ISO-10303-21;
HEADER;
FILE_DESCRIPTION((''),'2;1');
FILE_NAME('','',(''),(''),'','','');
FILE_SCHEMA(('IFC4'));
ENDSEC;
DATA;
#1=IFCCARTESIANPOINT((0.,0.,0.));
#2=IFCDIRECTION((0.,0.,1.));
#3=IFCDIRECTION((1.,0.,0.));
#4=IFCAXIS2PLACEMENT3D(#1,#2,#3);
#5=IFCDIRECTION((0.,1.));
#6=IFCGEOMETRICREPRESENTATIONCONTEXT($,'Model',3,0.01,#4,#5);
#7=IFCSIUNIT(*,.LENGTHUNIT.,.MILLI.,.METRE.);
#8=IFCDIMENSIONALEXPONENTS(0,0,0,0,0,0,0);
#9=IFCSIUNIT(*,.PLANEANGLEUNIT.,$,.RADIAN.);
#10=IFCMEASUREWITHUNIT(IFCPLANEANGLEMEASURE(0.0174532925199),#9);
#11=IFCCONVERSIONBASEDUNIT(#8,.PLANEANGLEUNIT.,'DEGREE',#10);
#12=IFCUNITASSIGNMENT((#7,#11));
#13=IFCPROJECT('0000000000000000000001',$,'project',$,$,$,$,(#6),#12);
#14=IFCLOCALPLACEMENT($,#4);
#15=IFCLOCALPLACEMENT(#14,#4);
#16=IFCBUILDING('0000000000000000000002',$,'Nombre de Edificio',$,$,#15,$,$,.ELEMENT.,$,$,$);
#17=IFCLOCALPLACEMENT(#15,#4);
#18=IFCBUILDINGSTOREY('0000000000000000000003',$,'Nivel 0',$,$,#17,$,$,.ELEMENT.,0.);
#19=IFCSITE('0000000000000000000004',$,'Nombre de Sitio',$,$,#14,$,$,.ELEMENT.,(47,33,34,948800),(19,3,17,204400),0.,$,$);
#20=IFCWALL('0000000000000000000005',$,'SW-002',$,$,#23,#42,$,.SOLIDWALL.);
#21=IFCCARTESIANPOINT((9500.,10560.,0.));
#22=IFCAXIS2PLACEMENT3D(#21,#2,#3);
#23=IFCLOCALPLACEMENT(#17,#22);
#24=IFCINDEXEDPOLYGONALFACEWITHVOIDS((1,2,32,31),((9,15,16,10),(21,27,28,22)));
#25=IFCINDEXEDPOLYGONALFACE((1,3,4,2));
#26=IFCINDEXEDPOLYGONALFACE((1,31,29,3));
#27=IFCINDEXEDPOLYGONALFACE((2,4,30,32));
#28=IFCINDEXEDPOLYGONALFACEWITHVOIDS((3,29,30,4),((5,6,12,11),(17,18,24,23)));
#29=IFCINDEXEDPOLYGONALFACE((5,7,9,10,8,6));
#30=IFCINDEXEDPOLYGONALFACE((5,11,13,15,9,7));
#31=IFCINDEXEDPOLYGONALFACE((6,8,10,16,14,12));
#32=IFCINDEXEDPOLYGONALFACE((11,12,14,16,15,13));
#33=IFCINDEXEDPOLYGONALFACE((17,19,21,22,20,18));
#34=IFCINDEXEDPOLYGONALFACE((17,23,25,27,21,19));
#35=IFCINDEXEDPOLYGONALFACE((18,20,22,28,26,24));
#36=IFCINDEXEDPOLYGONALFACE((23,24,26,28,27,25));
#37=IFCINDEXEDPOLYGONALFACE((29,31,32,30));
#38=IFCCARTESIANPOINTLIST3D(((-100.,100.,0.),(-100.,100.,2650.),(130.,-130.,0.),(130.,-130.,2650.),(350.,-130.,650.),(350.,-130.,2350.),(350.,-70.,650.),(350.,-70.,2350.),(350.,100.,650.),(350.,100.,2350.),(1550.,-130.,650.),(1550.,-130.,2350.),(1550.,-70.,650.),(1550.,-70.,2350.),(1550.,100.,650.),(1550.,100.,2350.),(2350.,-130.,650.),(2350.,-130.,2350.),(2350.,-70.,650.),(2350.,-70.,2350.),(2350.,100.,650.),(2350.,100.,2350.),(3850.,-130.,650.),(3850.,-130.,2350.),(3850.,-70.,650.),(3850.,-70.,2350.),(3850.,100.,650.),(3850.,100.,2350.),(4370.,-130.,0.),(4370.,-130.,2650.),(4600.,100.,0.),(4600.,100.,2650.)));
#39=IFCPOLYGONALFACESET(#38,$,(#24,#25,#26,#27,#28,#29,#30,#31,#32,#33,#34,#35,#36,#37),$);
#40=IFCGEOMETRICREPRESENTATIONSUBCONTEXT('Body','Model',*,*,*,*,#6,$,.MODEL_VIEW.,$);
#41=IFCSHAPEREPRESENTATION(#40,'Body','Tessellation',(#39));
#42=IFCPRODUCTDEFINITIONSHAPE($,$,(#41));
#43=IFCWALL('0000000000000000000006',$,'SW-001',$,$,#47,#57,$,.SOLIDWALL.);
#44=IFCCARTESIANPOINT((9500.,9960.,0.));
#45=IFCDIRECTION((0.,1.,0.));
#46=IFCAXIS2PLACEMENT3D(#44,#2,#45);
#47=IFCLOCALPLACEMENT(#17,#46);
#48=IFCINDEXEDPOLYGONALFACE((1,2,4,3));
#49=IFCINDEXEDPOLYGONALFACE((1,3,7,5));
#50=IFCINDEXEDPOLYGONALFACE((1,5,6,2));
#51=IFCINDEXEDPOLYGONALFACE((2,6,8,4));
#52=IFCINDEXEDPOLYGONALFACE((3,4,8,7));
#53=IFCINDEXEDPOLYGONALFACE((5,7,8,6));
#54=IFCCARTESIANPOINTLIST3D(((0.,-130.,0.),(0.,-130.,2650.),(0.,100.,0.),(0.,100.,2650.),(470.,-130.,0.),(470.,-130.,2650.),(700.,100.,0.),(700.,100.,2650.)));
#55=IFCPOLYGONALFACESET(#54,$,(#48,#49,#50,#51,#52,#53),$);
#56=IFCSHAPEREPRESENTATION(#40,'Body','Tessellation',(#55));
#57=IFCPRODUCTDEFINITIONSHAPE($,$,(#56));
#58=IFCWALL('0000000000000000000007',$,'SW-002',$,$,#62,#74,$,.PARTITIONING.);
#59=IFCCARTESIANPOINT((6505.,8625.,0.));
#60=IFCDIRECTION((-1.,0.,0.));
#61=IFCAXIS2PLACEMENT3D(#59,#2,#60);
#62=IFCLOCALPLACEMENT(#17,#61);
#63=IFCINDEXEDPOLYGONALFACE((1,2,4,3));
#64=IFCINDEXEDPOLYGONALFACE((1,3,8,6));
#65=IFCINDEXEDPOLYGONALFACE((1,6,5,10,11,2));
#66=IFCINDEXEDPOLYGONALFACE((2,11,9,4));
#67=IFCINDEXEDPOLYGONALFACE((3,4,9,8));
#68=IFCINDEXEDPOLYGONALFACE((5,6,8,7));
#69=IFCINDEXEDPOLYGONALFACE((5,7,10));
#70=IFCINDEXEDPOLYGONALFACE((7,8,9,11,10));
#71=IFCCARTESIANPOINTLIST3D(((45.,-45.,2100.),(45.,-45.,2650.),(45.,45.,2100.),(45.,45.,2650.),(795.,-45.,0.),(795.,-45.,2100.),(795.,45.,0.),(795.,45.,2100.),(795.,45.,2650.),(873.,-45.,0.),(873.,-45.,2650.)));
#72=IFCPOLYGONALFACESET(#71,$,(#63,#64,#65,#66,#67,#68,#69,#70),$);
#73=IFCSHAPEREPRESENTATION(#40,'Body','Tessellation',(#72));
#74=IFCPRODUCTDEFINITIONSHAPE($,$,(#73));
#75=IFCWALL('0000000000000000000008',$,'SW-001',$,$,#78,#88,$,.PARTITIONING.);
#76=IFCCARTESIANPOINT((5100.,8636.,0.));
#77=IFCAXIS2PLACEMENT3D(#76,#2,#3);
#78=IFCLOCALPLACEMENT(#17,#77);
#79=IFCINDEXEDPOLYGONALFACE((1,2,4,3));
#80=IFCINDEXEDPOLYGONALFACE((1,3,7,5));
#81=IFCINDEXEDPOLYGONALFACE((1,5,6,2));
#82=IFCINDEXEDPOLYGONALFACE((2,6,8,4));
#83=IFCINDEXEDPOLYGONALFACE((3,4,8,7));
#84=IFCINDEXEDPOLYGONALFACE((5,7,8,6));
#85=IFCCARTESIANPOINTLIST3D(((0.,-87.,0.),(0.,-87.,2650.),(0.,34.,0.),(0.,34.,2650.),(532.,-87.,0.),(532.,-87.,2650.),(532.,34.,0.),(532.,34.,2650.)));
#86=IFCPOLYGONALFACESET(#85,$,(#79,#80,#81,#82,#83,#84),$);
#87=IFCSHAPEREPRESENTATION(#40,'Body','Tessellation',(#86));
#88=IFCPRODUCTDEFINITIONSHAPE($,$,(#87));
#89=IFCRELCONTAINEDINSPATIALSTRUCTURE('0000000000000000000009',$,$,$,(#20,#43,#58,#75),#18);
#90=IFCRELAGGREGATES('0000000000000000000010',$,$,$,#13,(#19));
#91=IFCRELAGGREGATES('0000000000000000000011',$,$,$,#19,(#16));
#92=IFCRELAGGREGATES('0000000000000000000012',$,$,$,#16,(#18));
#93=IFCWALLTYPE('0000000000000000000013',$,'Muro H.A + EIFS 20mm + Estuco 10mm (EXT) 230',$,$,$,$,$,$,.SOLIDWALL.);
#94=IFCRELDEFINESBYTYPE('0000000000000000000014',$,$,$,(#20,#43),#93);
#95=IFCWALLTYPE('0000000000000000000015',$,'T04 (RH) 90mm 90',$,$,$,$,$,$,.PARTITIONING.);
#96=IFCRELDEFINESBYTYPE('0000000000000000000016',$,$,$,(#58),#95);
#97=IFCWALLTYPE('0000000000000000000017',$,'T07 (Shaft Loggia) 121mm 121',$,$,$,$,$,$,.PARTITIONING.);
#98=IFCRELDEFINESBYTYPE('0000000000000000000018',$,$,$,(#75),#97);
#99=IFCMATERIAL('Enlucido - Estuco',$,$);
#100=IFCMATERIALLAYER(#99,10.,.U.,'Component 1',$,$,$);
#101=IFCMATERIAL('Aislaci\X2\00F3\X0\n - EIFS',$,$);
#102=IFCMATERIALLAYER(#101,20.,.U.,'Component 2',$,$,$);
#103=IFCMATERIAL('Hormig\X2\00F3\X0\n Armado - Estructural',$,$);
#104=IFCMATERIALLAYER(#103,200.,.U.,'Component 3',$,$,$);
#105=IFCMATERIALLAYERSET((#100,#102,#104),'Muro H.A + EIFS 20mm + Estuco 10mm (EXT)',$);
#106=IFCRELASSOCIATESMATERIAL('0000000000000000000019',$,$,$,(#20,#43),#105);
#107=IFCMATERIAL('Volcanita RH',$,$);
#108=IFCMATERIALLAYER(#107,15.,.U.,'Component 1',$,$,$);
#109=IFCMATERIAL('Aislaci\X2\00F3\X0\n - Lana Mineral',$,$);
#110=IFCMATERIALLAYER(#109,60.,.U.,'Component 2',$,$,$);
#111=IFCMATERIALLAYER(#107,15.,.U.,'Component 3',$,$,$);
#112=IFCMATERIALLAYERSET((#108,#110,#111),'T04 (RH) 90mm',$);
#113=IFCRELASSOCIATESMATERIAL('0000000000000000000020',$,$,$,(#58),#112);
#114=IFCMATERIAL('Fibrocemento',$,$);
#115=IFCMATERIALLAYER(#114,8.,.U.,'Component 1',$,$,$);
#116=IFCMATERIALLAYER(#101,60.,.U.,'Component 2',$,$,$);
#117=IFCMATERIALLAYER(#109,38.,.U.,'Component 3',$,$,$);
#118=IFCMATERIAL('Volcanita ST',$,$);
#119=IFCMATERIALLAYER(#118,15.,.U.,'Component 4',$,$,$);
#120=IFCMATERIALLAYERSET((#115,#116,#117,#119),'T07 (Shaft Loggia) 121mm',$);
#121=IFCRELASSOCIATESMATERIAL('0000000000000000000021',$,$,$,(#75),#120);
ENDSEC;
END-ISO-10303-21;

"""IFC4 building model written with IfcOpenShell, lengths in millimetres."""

from ifc_helpers import new_model, entity, si_unit, converted_unit, direction, frame, origin_with_axes, origin_2d_with_axis, place, context, subcontext, project, spatial, line, indexed_curve, rectangle, outline, extrude, material, layer, layer_set, layer_usage, type_object, element, save


model = new_model("IFC4")

# Units and contexts
model_context = context("Model", 3, precision=0.01, world=origin_with_axes(), true_north=direction((0.0, 1.0)))
body_context = subcontext(model_context, "Body", "Model", "MODEL_VIEW")
ifc_project = project(units=[si_unit("LENGTHUNIT", "METRE", prefix="MILLI"), converted_unit("PLANEANGLEUNIT", "DEGREE", entity("IfcPlaneAngleMeasure", 0.0174532925199), si_unit("PLANEANGLEUNIT", "RADIAN"), dimensions=[0, 0, 0, 0, 0, 0, 0])], contexts=[model_context])

# Site, building, storey
site_placement = place(None, origin_with_axes())
site = spatial("IfcSite", under=ifc_project, at=site_placement, Name="Nombre de Sitio", CompositionType="ELEMENT", RefLatitude=(47, 33, 34, 948800), RefLongitude=(19, 3, 17, 204400), RefElevation=0.0)
building_placement = place(site_placement, origin_with_axes())
building = spatial("IfcBuilding", under=site, at=building_placement, Name="Nombre de Edificio", CompositionType="ELEMENT")
storey_placement = place(building_placement, origin_with_axes())
storey = spatial("IfcBuildingStorey", under=building, at=storey_placement, Name="Nivel 0", CompositionType="ELEMENT", Elevation=0.0)

# Wall, openings
ifc_material_1 = material(Name="Enlucido - Estuco")
ifc_layer_1 = layer(ifc_material_1, 10.0, ventilated="UNKNOWN", Name="Component 1")
ifc_material_2 = material(Name="Aislación - EIFS")
ifc_layer_2 = layer(ifc_material_2, 20.0, ventilated="UNKNOWN", Name="Component 2")
ifc_material_3 = material(Name="Hormigón Armado - Estructural")
ifc_layer_3 = layer(ifc_material_3, 200.0, ventilated="UNKNOWN", Name="Component 3")
ifc_layer_set_1 = layer_set([ifc_layer_1, ifc_layer_2, ifc_layer_3], Name="Muro H.A + EIFS 20mm + Estuco 10mm (EXT)")
ifc_layer_usage_1 = layer_usage(ifc_layer_set_1, "AXIS2", "POSITIVE", -130.0)
wall_type_1 = type_object("IfcWallType", Name="Muro H.A + EIFS 20mm + Estuco 10mm (EXT) 230", PredefinedType="SOLIDWALL")
wall_1_placement = place(storey_placement, frame((9500.0, 10560.0, 0.0), z_axis=(0.0, 0.0, 1.0), x_axis=(1.0, 0.0, 0.0)))
wall_1 = element("IfcWall", 1, at=wall_1_placement, inside=storey, type_object=wall_type_1, material=ifc_layer_usage_1, Name="SW-002", PredefinedType="SOLIDWALL", context=body_context, shape_type="SweptSolid", body=[
    extrude(outline(indexed_curve([(130.0, -130.0), (4370.0, -130.0), (4600.0, 100.0), (-100.0, 100.0)], segments=[line(1, 2, 3, 4, 1)])), origin_with_axes(), (0.0, 0.0, 1.0), 2650.0),
])
opening_1_placement = place(wall_1_placement, frame((950.0, 0.0, 650.0), z_axis=(0.0, 0.0, 1.0), x_axis=(1.0, 0.0, 0.0)))
element("IfcOpeningElement", 2, at=opening_1_placement, cuts=wall_1, context=body_context, shape_type="SweptSolid", body=[
    extrude(rectangle(XDim=1200.0, YDim=1700.0, at=origin_2d_with_axis()), frame((0.0, -70.0, 850.0), z_axis=(0.0, -1.0, 0.0), x_axis=(1.0, 0.0, 0.0)), (0.0, 0.0, -1.0), 400.0),
    extrude(rectangle(XDim=1200.0, YDim=1700.0, at=origin_2d_with_axis()), frame((0.0, -70.0, 850.0), z_axis=(0.0, 1.0, 0.0), x_axis=(1.0, 0.0, 0.0)), (0.0, 0.0, -1.0), 290.0),
])
opening_2_placement = place(wall_1_placement, frame((3100.0, 0.0, 650.0), z_axis=(0.0, 0.0, 1.0), x_axis=(1.0, 0.0, 0.0)))
element("IfcOpeningElement", 3, at=opening_2_placement, cuts=wall_1, context=body_context, shape_type="SweptSolid", body=[
    extrude(rectangle(XDim=1500.0, YDim=1700.0, at=origin_2d_with_axis()), frame((0.0, -70.0, 850.0), z_axis=(0.0, -1.0, 0.0), x_axis=(1.0, 0.0, 0.0)), (0.0, 0.0, -1.0), 400.0),
    extrude(rectangle(XDim=1500.0, YDim=1700.0, at=origin_2d_with_axis()), frame((0.0, -70.0, 850.0), z_axis=(0.0, 1.0, 0.0), x_axis=(1.0, 0.0, 0.0)), (0.0, 0.0, -1.0), 290.0),
])

# Wall
ifc_layer_usage_2 = layer_usage(ifc_layer_set_1, "AXIS2", "POSITIVE", -130.0)
wall_2_placement = place(storey_placement, frame((9500.0, 9960.0, 0.0), z_axis=(0.0, 0.0, 1.0), x_axis=(0.0, 1.0, 0.0)))
element("IfcWall", 4, at=wall_2_placement, inside=storey, type_object=wall_type_1, material=ifc_layer_usage_2, Name="SW-001", PredefinedType="SOLIDWALL", context=body_context, shape_type="SweptSolid", body=[
    extrude(outline(indexed_curve([(0.0, -130.0), (470.0, -130.0), (700.0, 100.0), (0.0, 100.0)], segments=[line(1, 2, 3, 4, 1)])), origin_with_axes(), (0.0, 0.0, 1.0), 2650.0),
])

# Wall, opening
ifc_material_4 = material(Name="Volcanita RH")
ifc_layer_4 = layer(ifc_material_4, 15.0, ventilated="UNKNOWN", Name="Component 1")
ifc_material_5 = material(Name="Aislación - Lana Mineral")
ifc_layer_5 = layer(ifc_material_5, 60.0, ventilated="UNKNOWN", Name="Component 2")
ifc_layer_6 = layer(ifc_material_4, 15.0, ventilated="UNKNOWN", Name="Component 3")
ifc_layer_set_2 = layer_set([ifc_layer_4, ifc_layer_5, ifc_layer_6], Name="T04 (RH) 90mm")
ifc_layer_usage_3 = layer_usage(ifc_layer_set_2, "AXIS2", "POSITIVE", -45.0)
wall_type_2 = type_object("IfcWallType", Name="T04 (RH) 90mm 90", PredefinedType="PARTITIONING")
wall_3_placement = place(storey_placement, frame((6505.0, 8625.0, 0.0), z_axis=(0.0, 0.0, 1.0), x_axis=(-1.0, 0.0, 0.0)))
wall_3 = element("IfcWall", 5, at=wall_3_placement, inside=storey, type_object=wall_type_2, material=ifc_layer_usage_3, Name="SW-002", PredefinedType="PARTITIONING", context=body_context, shape_type="SweptSolid", body=[
    extrude(outline(indexed_curve([(45.0, -45.0), (873.0, -45.0), (795.0, 45.0), (45.0, 45.0)], segments=[line(1, 2, 3, 4, 1)])), origin_with_axes(), (0.0, 0.0, 1.0), 2650.0),
])
opening_3_placement = place(wall_3_placement, frame((420.0, 0.0, 0.0), z_axis=(0.0, 0.0, 1.0), x_axis=(1.0, 0.0, 0.0)))
element("IfcOpeningElement", 6, at=opening_3_placement, cuts=wall_3, context=body_context, shape_type="SweptSolid", body=[
    extrude(rectangle(XDim=750.0, YDim=2100.0, at=origin_2d_with_axis()), frame((0.0, 90.0, 1050.0), z_axis=(0.0, -1.0, 0.0), x_axis=(-1.0, 0.0, 0.0)), (0.0, 0.0, 1.0), 270.0),
])

# Wall
ifc_material_6 = material(Name="Volcanita ST")
ifc_material_7 = material(Name="Fibrocemento")
ifc_layer_7 = layer(ifc_material_7, 8.0, ventilated="UNKNOWN", Name="Component 1")
ifc_layer_8 = layer(ifc_material_2, 60.0, ventilated="UNKNOWN", Name="Component 2")
ifc_layer_9 = layer(ifc_material_5, 38.0, ventilated="UNKNOWN", Name="Component 3")
ifc_layer_10 = layer(ifc_material_6, 15.0, ventilated="UNKNOWN", Name="Component 4")
ifc_layer_set_3 = layer_set([ifc_layer_7, ifc_layer_8, ifc_layer_9, ifc_layer_10], Name="T07 (Shaft Loggia) 121mm")
ifc_layer_usage_4 = layer_usage(ifc_layer_set_3, "AXIS2", "POSITIVE", -87.0)
wall_type_3 = type_object("IfcWallType", Name="T07 (Shaft Loggia) 121mm 121", PredefinedType="PARTITIONING")
wall_4_placement = place(storey_placement, frame((5100.0, 8636.0, 0.0), z_axis=(0.0, 0.0, 1.0), x_axis=(1.0, 0.0, 0.0)))
element("IfcWall", 7, at=wall_4_placement, inside=storey, type_object=wall_type_3, material=ifc_layer_usage_4, Name="SW-001", PredefinedType="PARTITIONING", context=body_context, shape_type="SweptSolid", body=[
    extrude(outline(indexed_curve([(0.0, -87.0), (532.0, -87.0), (532.0, 34.0), (0.0, 34.0)], segments=[line(1, 2, 3, 4, 1)])), origin_with_axes(), (0.0, 0.0, 1.0), 2650.0),
])

save(model, "model.ifc")
